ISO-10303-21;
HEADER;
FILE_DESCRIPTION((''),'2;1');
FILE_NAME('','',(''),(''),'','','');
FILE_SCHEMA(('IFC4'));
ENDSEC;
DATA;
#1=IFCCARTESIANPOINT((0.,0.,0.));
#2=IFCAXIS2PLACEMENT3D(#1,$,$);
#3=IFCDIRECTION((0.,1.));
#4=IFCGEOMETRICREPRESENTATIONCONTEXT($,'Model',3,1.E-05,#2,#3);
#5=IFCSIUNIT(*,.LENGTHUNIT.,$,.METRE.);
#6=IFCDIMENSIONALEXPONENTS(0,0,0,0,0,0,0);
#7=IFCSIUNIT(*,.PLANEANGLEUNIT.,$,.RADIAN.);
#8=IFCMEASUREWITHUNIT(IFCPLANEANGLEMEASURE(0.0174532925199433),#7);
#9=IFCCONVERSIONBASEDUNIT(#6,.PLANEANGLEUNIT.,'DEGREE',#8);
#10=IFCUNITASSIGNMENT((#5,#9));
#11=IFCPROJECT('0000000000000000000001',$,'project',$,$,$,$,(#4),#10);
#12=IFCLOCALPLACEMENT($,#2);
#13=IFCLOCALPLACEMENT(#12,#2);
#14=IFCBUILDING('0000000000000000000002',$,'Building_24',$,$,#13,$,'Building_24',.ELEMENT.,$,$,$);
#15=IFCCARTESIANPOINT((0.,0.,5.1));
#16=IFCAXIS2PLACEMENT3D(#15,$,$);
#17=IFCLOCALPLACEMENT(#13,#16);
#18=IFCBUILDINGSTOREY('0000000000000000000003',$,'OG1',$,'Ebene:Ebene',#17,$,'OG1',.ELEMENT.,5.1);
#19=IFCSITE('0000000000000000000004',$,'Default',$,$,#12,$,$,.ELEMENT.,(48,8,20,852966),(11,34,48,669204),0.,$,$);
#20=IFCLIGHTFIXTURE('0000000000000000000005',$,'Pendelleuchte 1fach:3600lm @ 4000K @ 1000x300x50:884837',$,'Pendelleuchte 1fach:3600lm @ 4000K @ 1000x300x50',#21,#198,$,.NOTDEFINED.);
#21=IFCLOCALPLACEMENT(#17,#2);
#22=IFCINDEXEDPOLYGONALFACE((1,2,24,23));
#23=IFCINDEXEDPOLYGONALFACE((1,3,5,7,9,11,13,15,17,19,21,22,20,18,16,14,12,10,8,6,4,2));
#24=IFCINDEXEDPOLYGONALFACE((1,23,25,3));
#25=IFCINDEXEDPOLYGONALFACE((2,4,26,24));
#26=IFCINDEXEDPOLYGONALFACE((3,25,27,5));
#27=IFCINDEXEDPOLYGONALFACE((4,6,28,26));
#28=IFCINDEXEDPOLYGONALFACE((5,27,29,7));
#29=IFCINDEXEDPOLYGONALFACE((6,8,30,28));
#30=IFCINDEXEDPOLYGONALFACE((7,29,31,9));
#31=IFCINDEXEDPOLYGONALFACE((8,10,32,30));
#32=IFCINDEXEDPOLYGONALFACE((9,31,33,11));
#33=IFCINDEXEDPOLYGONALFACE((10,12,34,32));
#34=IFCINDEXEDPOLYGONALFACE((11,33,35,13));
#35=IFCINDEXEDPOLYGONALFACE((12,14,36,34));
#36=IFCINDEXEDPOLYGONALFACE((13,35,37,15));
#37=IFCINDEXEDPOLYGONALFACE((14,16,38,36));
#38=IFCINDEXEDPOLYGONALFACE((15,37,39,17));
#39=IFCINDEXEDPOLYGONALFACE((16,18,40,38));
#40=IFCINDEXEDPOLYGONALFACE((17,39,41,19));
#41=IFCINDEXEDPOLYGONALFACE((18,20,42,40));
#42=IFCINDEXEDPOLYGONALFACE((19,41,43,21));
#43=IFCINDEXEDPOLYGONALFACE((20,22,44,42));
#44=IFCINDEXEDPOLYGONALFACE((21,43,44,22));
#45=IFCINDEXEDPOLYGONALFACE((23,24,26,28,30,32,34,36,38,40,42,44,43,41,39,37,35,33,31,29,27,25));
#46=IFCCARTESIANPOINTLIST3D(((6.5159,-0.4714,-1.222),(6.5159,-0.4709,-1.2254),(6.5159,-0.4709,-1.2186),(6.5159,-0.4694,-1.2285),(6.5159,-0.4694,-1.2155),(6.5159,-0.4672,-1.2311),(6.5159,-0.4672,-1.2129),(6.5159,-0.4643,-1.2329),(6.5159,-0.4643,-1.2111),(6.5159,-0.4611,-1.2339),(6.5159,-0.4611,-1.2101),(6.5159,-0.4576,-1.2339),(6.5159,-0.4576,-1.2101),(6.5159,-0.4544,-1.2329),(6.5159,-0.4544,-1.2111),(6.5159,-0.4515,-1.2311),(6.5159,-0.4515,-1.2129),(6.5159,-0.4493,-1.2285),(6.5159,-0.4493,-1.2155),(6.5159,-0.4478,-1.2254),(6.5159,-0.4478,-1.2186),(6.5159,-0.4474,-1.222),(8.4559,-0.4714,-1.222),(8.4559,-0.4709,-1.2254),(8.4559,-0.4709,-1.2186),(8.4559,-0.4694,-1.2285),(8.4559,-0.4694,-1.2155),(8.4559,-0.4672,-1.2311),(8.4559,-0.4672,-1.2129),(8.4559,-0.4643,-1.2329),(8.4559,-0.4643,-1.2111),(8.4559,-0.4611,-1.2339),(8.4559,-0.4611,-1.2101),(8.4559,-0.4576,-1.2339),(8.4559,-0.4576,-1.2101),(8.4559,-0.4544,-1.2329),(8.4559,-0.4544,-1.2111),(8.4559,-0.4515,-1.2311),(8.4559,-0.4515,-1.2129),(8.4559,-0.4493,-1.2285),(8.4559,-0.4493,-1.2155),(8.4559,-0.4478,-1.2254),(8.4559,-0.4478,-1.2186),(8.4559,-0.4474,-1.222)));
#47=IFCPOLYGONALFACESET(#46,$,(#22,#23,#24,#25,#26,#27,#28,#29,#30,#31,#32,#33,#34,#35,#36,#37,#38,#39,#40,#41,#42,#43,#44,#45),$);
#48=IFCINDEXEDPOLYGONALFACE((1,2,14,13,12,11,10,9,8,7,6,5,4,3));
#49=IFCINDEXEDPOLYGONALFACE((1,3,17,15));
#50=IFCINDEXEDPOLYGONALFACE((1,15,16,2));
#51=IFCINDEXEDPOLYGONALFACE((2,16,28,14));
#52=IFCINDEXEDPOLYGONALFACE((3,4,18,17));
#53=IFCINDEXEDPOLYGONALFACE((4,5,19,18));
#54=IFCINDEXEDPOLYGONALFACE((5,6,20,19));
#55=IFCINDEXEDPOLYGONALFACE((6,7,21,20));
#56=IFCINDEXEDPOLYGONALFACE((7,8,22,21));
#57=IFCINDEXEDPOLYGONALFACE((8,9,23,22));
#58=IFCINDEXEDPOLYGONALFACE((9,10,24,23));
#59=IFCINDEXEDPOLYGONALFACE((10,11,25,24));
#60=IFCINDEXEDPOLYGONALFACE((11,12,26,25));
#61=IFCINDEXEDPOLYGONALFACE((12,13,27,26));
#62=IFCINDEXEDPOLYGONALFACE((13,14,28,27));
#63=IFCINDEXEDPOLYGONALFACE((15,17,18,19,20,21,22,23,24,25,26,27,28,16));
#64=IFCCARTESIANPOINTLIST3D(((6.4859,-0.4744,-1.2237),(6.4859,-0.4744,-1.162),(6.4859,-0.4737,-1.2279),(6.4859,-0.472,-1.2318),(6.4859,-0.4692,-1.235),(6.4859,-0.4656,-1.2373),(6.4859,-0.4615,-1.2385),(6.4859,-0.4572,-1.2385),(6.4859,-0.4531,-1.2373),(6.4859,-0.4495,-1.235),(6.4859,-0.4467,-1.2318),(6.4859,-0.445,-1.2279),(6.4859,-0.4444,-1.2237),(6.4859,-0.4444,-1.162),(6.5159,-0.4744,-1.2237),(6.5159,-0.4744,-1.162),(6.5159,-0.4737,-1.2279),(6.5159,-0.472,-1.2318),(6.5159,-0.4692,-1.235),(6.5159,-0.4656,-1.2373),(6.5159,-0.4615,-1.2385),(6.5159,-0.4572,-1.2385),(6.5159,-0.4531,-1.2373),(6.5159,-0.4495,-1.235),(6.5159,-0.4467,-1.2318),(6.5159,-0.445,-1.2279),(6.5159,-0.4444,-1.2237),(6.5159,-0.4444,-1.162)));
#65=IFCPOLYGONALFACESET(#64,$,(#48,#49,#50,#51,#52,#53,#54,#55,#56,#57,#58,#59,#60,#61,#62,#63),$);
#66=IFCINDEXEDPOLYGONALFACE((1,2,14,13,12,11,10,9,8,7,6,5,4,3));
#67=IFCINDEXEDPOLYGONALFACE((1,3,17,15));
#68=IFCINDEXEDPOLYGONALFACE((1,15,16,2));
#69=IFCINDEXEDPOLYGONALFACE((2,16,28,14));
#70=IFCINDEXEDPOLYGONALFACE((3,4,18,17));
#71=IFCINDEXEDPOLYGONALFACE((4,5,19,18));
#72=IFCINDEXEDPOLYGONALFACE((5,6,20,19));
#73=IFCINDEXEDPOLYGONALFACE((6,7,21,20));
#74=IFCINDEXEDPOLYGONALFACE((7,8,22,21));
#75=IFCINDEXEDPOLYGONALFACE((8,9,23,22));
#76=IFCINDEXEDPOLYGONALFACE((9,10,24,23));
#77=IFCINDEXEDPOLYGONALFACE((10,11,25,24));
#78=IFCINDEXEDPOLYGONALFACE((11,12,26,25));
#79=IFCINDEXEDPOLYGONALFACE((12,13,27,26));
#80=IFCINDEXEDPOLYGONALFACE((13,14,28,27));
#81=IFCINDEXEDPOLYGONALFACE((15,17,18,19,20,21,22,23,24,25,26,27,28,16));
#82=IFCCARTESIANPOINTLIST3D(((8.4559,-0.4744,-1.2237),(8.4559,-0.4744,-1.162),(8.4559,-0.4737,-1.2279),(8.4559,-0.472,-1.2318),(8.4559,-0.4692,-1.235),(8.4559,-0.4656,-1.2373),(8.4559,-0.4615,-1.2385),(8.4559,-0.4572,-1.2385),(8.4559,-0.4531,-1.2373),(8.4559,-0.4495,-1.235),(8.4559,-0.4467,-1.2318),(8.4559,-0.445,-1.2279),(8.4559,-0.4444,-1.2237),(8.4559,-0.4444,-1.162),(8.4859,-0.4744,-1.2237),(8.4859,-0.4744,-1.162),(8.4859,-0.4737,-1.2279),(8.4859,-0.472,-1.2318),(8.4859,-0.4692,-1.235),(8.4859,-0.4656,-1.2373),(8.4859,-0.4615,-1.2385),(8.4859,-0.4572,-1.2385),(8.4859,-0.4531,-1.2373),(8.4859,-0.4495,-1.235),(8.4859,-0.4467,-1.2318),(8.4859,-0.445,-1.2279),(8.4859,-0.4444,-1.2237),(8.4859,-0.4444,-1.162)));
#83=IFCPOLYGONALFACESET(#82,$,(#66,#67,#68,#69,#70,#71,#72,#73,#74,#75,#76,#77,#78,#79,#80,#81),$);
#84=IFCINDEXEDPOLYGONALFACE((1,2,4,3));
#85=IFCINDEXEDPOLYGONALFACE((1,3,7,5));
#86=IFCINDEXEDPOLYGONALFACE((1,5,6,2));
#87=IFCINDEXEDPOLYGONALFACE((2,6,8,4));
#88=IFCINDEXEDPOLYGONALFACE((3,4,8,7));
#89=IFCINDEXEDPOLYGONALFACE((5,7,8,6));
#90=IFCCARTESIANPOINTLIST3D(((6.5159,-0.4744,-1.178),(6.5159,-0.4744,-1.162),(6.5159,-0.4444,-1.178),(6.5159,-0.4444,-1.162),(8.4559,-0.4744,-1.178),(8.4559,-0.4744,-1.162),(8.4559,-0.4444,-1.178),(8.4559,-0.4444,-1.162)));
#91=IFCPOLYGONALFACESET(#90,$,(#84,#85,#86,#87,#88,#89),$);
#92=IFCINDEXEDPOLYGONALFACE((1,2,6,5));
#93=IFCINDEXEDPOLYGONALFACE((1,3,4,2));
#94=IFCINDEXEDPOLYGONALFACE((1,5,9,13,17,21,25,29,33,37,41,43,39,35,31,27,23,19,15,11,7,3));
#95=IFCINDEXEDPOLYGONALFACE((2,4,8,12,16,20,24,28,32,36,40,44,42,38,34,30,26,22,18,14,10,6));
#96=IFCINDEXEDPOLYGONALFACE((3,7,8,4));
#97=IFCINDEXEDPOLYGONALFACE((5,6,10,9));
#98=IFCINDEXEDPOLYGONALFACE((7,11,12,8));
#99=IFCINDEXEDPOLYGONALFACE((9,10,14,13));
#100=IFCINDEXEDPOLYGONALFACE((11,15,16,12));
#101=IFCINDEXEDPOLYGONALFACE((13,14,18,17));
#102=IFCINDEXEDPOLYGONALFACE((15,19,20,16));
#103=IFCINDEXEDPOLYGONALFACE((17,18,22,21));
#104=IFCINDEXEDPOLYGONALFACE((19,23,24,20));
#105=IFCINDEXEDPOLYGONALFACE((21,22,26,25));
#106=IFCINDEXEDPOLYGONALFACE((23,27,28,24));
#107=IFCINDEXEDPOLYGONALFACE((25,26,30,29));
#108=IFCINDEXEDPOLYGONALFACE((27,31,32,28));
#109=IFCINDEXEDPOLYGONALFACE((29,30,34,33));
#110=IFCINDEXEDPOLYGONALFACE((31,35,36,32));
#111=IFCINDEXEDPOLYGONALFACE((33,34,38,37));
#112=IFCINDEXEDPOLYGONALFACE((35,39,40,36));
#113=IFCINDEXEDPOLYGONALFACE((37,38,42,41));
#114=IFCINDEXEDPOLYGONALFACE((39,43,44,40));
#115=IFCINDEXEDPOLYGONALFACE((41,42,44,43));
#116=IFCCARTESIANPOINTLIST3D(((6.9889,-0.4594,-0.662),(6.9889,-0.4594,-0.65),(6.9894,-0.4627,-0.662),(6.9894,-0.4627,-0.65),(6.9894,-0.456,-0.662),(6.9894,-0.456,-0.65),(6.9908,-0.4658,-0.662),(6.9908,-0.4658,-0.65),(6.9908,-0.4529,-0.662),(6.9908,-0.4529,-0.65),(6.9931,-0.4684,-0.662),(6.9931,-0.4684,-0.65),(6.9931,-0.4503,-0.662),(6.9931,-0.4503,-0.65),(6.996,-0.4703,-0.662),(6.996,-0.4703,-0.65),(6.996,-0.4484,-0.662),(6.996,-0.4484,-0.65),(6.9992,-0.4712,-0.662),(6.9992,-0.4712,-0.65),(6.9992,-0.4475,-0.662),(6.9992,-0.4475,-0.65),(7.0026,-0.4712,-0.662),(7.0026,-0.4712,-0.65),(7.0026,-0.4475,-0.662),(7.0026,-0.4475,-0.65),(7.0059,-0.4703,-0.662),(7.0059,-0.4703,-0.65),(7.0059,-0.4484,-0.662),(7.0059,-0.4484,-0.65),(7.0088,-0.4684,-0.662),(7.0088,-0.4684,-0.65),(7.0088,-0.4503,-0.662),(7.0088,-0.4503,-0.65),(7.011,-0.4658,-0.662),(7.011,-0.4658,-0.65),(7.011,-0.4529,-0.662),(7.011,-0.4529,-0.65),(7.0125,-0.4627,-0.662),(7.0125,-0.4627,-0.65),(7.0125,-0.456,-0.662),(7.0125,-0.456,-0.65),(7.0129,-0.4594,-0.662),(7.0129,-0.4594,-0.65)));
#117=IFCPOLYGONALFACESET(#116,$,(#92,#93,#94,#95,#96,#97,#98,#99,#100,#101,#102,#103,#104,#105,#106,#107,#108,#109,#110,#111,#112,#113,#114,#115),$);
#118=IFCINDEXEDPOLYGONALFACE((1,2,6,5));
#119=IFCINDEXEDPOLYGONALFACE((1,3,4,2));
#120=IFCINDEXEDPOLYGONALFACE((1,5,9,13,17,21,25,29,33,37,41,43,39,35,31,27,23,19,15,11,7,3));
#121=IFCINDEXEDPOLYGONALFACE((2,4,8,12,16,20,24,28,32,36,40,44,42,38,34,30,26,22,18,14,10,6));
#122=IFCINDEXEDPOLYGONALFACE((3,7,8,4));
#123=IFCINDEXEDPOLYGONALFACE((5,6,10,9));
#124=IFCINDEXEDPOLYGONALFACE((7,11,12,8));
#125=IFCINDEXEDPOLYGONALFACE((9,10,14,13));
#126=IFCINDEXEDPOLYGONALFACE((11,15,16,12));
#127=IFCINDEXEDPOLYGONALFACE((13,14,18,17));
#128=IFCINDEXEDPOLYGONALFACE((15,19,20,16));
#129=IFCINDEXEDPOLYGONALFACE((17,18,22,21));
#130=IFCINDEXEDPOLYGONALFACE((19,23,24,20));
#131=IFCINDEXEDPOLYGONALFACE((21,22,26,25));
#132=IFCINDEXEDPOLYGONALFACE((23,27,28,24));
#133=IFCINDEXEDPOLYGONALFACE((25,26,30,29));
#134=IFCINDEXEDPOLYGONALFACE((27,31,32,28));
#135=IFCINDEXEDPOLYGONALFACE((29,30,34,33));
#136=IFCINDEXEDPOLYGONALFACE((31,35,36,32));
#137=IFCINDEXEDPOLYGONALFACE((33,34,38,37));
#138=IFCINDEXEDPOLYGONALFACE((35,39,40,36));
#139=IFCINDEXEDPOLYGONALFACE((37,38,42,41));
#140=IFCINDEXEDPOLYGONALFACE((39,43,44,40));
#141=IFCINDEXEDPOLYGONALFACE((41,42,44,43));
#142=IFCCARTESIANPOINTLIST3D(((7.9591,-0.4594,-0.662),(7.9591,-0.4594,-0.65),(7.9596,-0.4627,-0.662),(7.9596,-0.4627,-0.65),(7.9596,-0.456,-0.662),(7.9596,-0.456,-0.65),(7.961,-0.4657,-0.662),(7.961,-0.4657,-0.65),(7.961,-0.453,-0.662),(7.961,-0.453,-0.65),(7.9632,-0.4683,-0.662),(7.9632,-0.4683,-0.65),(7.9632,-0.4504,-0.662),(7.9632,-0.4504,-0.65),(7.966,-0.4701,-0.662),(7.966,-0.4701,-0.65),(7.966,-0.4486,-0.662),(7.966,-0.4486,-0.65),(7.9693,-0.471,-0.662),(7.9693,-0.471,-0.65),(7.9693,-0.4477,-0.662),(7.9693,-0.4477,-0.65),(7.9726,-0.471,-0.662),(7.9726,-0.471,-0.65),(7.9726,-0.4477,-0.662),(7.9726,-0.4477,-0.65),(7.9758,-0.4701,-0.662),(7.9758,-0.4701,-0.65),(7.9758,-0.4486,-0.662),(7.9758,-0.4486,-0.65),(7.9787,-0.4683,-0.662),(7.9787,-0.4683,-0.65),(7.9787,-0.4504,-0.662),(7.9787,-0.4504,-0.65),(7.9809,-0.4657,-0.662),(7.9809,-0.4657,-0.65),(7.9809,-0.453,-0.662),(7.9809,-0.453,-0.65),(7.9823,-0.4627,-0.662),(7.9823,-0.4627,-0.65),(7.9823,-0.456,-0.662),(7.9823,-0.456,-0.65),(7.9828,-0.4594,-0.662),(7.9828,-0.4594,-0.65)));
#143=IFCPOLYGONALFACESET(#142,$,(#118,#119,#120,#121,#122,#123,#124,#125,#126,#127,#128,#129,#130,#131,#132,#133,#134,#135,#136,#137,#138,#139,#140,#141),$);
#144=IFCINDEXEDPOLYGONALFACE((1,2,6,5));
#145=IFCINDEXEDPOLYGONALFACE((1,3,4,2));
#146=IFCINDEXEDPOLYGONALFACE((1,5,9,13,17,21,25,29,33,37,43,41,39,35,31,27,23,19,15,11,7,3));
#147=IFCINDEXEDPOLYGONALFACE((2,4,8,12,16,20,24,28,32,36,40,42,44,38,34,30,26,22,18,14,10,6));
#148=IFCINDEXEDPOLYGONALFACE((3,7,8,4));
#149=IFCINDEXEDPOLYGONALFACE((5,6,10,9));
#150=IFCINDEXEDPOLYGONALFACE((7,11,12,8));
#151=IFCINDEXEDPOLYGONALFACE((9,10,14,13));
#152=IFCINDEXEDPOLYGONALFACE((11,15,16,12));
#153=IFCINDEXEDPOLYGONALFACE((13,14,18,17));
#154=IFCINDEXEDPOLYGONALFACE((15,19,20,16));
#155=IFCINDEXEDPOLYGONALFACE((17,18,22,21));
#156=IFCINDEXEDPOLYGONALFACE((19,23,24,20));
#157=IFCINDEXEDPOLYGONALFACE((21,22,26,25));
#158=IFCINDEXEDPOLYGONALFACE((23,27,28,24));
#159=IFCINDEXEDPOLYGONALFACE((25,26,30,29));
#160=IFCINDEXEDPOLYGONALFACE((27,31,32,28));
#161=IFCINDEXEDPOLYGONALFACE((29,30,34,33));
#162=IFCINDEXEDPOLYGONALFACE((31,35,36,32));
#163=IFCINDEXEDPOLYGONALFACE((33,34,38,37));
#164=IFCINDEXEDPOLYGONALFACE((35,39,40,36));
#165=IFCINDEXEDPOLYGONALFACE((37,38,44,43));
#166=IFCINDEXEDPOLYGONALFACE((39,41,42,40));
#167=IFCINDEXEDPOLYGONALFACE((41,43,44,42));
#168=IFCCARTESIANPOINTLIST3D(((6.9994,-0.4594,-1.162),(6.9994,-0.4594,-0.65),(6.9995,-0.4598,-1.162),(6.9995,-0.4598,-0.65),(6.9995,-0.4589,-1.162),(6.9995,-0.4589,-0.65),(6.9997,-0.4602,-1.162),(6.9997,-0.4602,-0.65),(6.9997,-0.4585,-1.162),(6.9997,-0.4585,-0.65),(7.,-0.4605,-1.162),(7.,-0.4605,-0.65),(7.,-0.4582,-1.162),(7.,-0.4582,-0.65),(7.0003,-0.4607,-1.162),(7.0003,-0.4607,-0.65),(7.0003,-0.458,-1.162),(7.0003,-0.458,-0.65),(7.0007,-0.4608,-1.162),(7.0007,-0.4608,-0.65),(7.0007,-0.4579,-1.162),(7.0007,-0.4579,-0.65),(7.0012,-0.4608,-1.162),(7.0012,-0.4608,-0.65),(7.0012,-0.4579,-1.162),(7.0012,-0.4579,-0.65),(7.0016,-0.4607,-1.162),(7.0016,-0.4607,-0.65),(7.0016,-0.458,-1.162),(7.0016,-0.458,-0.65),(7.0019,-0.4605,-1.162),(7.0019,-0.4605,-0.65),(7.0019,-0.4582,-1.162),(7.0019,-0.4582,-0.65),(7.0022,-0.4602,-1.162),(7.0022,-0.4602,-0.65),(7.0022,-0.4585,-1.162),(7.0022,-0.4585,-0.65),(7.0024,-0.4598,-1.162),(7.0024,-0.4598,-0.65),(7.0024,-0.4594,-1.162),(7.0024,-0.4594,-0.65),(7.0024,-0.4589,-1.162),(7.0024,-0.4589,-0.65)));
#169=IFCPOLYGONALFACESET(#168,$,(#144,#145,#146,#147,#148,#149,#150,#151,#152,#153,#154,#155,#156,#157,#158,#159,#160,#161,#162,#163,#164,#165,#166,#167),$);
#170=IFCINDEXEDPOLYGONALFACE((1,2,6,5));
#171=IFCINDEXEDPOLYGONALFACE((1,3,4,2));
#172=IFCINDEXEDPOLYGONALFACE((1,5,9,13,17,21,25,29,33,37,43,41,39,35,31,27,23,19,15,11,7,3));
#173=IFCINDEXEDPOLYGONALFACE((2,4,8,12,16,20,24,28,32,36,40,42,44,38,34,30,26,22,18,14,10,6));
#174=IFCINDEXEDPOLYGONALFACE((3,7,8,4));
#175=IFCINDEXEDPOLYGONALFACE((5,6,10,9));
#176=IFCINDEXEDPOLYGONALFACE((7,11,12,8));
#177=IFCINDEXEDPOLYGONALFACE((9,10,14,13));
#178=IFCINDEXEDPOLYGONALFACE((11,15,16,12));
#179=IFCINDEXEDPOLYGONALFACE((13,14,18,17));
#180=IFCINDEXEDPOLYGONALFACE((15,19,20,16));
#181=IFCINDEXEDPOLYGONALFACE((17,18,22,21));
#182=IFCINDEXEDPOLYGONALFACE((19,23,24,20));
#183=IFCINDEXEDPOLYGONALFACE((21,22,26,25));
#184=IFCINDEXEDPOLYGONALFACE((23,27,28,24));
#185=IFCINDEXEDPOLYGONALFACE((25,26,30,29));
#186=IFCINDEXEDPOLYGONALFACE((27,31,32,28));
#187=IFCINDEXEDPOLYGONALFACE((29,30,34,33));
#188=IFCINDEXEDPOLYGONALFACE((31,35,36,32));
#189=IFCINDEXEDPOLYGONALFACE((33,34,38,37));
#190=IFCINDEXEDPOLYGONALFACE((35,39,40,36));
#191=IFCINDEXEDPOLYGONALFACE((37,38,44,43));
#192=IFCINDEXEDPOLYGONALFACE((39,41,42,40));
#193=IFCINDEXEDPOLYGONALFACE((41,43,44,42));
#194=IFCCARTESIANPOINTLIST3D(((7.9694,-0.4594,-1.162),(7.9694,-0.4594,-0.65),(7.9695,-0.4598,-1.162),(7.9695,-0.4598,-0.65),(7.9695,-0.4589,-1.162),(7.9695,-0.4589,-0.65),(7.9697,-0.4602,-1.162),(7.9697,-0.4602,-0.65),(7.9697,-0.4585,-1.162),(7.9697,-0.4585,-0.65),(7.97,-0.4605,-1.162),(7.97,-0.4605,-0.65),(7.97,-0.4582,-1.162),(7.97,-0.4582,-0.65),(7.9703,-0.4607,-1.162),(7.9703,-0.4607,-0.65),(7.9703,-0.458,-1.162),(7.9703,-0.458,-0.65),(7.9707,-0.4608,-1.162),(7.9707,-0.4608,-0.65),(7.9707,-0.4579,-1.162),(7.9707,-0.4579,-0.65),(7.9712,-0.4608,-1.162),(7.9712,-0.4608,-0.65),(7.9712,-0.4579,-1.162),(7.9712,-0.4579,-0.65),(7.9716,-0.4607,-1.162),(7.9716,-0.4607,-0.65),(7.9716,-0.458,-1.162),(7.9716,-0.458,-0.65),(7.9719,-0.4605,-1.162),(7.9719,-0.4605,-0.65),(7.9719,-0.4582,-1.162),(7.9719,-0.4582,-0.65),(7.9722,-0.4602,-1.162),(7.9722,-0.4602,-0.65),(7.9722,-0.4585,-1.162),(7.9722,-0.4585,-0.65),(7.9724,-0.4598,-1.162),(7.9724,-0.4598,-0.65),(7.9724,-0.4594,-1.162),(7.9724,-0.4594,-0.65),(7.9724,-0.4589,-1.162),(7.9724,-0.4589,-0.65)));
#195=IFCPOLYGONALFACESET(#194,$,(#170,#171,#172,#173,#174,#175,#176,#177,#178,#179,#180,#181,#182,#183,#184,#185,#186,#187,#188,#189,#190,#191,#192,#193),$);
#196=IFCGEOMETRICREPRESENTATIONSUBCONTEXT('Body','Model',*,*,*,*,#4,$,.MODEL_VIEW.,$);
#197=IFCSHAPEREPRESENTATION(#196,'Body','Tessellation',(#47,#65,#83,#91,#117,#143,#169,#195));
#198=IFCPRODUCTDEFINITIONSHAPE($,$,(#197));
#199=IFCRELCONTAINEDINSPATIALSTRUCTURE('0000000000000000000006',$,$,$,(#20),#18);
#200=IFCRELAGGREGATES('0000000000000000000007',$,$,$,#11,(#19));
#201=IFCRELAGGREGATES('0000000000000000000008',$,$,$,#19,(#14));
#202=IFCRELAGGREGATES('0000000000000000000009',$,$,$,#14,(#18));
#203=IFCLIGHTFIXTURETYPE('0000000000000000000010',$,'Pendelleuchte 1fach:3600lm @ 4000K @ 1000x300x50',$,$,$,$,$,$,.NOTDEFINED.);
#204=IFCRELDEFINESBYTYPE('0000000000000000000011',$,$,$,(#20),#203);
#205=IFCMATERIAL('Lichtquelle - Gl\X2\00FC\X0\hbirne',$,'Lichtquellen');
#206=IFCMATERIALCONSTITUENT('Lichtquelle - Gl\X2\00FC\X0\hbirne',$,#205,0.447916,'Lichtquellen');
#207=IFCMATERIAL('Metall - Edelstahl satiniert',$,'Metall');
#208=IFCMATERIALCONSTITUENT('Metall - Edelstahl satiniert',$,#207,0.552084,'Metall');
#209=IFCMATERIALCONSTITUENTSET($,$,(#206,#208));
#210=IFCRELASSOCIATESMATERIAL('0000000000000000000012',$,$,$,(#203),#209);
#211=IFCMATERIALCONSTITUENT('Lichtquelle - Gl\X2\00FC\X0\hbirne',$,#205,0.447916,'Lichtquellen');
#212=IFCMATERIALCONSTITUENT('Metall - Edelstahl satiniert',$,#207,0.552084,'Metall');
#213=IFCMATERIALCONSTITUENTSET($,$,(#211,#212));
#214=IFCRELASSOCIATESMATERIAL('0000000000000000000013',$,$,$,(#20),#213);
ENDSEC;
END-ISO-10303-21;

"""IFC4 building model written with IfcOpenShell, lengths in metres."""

from ifc_helpers import new_model, entity, si_unit, converted_unit, direction, frame, origin, place, context, subcontext, project, spatial, line, arc, indexed_curve, outline, extrude, source, transform, mapped, material, constituent, constituent_set, type_object, type_shapes, element, save


model = new_model("IFC4")

# Units and contexts
model_context = context("Model", 3, precision=1e-05, world=origin(), true_north=direction((0.0, 1.0)))
body_context = subcontext(model_context, "Body", "Model", "MODEL_VIEW")
ifc_project = project(units=[si_unit("LENGTHUNIT", "METRE"), converted_unit("PLANEANGLEUNIT", "DEGREE", entity("IfcPlaneAngleMeasure", 0.0174532925199433), si_unit("PLANEANGLEUNIT", "RADIAN"), dimensions=[0, 0, 0, 0, 0, 0, 0])], contexts=[model_context])

# Site, building, storey
site_placement = place(None, origin())
site = spatial("IfcSite", under=ifc_project, at=site_placement, Name="Default", CompositionType="ELEMENT", RefLatitude=(48, 8, 20, 852966), RefLongitude=(11, 34, 48, 669204), RefElevation=0.0)
building_placement = place(site_placement, origin())
building = spatial("IfcBuilding", under=site, at=building_placement, Name="Building_24", LongName="Building_24", CompositionType="ELEMENT")
storey_placement = place(building_placement, frame((0.0, 0.0, 5.1)))
storey = spatial("IfcBuildingStorey", under=building, at=storey_placement, Name="OG1", ObjectType="Ebene:Ebene", LongName="OG1", CompositionType="ELEMENT", Elevation=5.1)

# Light fixture
ifc_material_1 = material(Name="Lichtquelle - Glühbirne", Category="Lichtquellen")
ifc_material_2 = material(Name="Metall - Edelstahl satiniert", Category="Metall")
ifc_constituent_1 = constituent(ifc_material_1, Name="Lichtquelle - Glühbirne", Category="Lichtquellen", fraction=0.447916)
ifc_constituent_2 = constituent(ifc_material_2, Name="Metall - Edelstahl satiniert", Category="Metall", fraction=0.552084)
ifc_constituent_set_1 = constituent_set(constituents=[ifc_constituent_1, ifc_constituent_2])
light_fixture_type_1 = type_object("IfcLightFixtureType", Name="Pendelleuchte 1fach:3600lm @ 4000K @ 1000x300x50", PredefinedType="NOTDEFINED", material=ifc_constituent_set_1)
shared_shape_1 = source(origin(), body_context, "Body", "SweptSolid", [
    extrude(outline(indexed_curve([(-0.012, 0.0), (0.0, -0.012), (0.012, 0.0), (0.0, 0.012)], segments=[arc(1, 2, 3), arc(3, 4, 1)], self_intersect=False)), frame((-0.97, 0.0, -0.572), z_axis=(1.0, 0.0, 0.0), x_axis=(0.0, -1.0, 0.0)), (0.0, 0.0, 1.0), 1.94),
    extrude(outline(indexed_curve([(0.015, 0.0308), (0.0, 0.0458), (-0.015, 0.0308), (-0.015, -0.0308), (0.015, -0.0308)], segments=[arc(1, 2, 3), line(3, 4, 5, 1)], self_intersect=False)), frame((0.97, 0.0, -0.5428), z_axis=(1.0, 0.0, 0.0), x_axis=(0.0, -1.0, 0.0)), (0.0, 0.0, 1.0), 0.03),
    extrude(outline(indexed_curve([(0.015, 0.0308), (0.0, 0.0458), (-0.015, 0.0308), (-0.015, -0.0308), (0.015, -0.0308)], segments=[arc(1, 2, 3), line(3, 4, 5, 1)], self_intersect=False)), frame((-1.0, 0.0, -0.5428), z_axis=(1.0, 0.0, 0.0), x_axis=(0.0, -1.0, 0.0)), (0.0, 0.0, 1.0), 0.03),
    extrude(outline(indexed_curve([(-0.015, -0.97), (0.015, -0.97), (0.015, 0.97), (-0.015, 0.97), (-0.015, -0.97)], self_intersect=False)), frame((0.0, 0.0, -0.528), z_axis=(0.0, 0.0, 1.0), x_axis=(0.0, 1.0, 0.0)), (0.0, 0.0, 1.0), 0.016),
    extrude(outline(indexed_curve([(-0.012, 0.0), (0.0, -0.012), (0.012, 0.0), (0.0, 0.012)], segments=[arc(1, 2, 3), arc(3, 4, 1)], self_intersect=False)), frame((0.485, 0.0, -0.012)), (0.0, 0.0, 1.0), 0.012),
    extrude(outline(indexed_curve([(-0.0118, 0.0), (0.0, -0.0118), (0.0118, 0.0), (0.0, 0.0118)], segments=[arc(1, 2, 3), arc(3, 4, 1)], self_intersect=False)), frame((-0.485, 0.0, -0.012)), (0.0, 0.0, 1.0), 0.012),
    extrude(outline(indexed_curve([(-0.0015, 0.0), (0.0, -0.0015), (0.0015, 0.0), (0.0, 0.0015)], segments=[arc(1, 2, 3), arc(3, 4, 1)], self_intersect=False)), frame((0.485, 0.0, -0.512)), (0.0, 0.0, 1.0), 0.512),
    extrude(outline(indexed_curve([(-0.0015, 0.0), (0.0, -0.0015), (0.0015, 0.0), (0.0, 0.0015)], segments=[arc(1, 2, 3), arc(3, 4, 1)], self_intersect=False)), frame((-0.485, 0.0, -0.512)), (0.0, 0.0, 1.0), 0.512),
])
type_shapes(light_fixture_type_1, [shared_shape_1])
ifc_constituent_3 = constituent(ifc_material_1, Name="Lichtquelle - Glühbirne", Category="Lichtquellen", fraction=0.447916)
ifc_constituent_4 = constituent(ifc_material_2, Name="Metall - Edelstahl satiniert", Category="Metall", fraction=0.552084)
ifc_constituent_set_2 = constituent_set(constituents=[ifc_constituent_3, ifc_constituent_4])
light_fixture_1_placement = place(storey_placement, frame((7.4859, -0.4594, -0.65), z_axis=(0.0, 0.0, 1.0), x_axis=(-1.0, 0.0, 0.0)))
element("IfcLightFixture", 1, at=light_fixture_1_placement, inside=storey, type_object=light_fixture_type_1, material=ifc_constituent_set_2, Name="Pendelleuchte 1fach:3600lm @ 4000K @ 1000x300x50:884837", ObjectType="Pendelleuchte 1fach:3600lm @ 4000K @ 1000x300x50", PredefinedType="NOTDEFINED", context=body_context, shape_type="MappedRepresentation", body=[
    mapped(shared_shape_1, transform((0.0, 0.0, 0.0), scale=1.0)),
])

save(model, "model.ifc")
